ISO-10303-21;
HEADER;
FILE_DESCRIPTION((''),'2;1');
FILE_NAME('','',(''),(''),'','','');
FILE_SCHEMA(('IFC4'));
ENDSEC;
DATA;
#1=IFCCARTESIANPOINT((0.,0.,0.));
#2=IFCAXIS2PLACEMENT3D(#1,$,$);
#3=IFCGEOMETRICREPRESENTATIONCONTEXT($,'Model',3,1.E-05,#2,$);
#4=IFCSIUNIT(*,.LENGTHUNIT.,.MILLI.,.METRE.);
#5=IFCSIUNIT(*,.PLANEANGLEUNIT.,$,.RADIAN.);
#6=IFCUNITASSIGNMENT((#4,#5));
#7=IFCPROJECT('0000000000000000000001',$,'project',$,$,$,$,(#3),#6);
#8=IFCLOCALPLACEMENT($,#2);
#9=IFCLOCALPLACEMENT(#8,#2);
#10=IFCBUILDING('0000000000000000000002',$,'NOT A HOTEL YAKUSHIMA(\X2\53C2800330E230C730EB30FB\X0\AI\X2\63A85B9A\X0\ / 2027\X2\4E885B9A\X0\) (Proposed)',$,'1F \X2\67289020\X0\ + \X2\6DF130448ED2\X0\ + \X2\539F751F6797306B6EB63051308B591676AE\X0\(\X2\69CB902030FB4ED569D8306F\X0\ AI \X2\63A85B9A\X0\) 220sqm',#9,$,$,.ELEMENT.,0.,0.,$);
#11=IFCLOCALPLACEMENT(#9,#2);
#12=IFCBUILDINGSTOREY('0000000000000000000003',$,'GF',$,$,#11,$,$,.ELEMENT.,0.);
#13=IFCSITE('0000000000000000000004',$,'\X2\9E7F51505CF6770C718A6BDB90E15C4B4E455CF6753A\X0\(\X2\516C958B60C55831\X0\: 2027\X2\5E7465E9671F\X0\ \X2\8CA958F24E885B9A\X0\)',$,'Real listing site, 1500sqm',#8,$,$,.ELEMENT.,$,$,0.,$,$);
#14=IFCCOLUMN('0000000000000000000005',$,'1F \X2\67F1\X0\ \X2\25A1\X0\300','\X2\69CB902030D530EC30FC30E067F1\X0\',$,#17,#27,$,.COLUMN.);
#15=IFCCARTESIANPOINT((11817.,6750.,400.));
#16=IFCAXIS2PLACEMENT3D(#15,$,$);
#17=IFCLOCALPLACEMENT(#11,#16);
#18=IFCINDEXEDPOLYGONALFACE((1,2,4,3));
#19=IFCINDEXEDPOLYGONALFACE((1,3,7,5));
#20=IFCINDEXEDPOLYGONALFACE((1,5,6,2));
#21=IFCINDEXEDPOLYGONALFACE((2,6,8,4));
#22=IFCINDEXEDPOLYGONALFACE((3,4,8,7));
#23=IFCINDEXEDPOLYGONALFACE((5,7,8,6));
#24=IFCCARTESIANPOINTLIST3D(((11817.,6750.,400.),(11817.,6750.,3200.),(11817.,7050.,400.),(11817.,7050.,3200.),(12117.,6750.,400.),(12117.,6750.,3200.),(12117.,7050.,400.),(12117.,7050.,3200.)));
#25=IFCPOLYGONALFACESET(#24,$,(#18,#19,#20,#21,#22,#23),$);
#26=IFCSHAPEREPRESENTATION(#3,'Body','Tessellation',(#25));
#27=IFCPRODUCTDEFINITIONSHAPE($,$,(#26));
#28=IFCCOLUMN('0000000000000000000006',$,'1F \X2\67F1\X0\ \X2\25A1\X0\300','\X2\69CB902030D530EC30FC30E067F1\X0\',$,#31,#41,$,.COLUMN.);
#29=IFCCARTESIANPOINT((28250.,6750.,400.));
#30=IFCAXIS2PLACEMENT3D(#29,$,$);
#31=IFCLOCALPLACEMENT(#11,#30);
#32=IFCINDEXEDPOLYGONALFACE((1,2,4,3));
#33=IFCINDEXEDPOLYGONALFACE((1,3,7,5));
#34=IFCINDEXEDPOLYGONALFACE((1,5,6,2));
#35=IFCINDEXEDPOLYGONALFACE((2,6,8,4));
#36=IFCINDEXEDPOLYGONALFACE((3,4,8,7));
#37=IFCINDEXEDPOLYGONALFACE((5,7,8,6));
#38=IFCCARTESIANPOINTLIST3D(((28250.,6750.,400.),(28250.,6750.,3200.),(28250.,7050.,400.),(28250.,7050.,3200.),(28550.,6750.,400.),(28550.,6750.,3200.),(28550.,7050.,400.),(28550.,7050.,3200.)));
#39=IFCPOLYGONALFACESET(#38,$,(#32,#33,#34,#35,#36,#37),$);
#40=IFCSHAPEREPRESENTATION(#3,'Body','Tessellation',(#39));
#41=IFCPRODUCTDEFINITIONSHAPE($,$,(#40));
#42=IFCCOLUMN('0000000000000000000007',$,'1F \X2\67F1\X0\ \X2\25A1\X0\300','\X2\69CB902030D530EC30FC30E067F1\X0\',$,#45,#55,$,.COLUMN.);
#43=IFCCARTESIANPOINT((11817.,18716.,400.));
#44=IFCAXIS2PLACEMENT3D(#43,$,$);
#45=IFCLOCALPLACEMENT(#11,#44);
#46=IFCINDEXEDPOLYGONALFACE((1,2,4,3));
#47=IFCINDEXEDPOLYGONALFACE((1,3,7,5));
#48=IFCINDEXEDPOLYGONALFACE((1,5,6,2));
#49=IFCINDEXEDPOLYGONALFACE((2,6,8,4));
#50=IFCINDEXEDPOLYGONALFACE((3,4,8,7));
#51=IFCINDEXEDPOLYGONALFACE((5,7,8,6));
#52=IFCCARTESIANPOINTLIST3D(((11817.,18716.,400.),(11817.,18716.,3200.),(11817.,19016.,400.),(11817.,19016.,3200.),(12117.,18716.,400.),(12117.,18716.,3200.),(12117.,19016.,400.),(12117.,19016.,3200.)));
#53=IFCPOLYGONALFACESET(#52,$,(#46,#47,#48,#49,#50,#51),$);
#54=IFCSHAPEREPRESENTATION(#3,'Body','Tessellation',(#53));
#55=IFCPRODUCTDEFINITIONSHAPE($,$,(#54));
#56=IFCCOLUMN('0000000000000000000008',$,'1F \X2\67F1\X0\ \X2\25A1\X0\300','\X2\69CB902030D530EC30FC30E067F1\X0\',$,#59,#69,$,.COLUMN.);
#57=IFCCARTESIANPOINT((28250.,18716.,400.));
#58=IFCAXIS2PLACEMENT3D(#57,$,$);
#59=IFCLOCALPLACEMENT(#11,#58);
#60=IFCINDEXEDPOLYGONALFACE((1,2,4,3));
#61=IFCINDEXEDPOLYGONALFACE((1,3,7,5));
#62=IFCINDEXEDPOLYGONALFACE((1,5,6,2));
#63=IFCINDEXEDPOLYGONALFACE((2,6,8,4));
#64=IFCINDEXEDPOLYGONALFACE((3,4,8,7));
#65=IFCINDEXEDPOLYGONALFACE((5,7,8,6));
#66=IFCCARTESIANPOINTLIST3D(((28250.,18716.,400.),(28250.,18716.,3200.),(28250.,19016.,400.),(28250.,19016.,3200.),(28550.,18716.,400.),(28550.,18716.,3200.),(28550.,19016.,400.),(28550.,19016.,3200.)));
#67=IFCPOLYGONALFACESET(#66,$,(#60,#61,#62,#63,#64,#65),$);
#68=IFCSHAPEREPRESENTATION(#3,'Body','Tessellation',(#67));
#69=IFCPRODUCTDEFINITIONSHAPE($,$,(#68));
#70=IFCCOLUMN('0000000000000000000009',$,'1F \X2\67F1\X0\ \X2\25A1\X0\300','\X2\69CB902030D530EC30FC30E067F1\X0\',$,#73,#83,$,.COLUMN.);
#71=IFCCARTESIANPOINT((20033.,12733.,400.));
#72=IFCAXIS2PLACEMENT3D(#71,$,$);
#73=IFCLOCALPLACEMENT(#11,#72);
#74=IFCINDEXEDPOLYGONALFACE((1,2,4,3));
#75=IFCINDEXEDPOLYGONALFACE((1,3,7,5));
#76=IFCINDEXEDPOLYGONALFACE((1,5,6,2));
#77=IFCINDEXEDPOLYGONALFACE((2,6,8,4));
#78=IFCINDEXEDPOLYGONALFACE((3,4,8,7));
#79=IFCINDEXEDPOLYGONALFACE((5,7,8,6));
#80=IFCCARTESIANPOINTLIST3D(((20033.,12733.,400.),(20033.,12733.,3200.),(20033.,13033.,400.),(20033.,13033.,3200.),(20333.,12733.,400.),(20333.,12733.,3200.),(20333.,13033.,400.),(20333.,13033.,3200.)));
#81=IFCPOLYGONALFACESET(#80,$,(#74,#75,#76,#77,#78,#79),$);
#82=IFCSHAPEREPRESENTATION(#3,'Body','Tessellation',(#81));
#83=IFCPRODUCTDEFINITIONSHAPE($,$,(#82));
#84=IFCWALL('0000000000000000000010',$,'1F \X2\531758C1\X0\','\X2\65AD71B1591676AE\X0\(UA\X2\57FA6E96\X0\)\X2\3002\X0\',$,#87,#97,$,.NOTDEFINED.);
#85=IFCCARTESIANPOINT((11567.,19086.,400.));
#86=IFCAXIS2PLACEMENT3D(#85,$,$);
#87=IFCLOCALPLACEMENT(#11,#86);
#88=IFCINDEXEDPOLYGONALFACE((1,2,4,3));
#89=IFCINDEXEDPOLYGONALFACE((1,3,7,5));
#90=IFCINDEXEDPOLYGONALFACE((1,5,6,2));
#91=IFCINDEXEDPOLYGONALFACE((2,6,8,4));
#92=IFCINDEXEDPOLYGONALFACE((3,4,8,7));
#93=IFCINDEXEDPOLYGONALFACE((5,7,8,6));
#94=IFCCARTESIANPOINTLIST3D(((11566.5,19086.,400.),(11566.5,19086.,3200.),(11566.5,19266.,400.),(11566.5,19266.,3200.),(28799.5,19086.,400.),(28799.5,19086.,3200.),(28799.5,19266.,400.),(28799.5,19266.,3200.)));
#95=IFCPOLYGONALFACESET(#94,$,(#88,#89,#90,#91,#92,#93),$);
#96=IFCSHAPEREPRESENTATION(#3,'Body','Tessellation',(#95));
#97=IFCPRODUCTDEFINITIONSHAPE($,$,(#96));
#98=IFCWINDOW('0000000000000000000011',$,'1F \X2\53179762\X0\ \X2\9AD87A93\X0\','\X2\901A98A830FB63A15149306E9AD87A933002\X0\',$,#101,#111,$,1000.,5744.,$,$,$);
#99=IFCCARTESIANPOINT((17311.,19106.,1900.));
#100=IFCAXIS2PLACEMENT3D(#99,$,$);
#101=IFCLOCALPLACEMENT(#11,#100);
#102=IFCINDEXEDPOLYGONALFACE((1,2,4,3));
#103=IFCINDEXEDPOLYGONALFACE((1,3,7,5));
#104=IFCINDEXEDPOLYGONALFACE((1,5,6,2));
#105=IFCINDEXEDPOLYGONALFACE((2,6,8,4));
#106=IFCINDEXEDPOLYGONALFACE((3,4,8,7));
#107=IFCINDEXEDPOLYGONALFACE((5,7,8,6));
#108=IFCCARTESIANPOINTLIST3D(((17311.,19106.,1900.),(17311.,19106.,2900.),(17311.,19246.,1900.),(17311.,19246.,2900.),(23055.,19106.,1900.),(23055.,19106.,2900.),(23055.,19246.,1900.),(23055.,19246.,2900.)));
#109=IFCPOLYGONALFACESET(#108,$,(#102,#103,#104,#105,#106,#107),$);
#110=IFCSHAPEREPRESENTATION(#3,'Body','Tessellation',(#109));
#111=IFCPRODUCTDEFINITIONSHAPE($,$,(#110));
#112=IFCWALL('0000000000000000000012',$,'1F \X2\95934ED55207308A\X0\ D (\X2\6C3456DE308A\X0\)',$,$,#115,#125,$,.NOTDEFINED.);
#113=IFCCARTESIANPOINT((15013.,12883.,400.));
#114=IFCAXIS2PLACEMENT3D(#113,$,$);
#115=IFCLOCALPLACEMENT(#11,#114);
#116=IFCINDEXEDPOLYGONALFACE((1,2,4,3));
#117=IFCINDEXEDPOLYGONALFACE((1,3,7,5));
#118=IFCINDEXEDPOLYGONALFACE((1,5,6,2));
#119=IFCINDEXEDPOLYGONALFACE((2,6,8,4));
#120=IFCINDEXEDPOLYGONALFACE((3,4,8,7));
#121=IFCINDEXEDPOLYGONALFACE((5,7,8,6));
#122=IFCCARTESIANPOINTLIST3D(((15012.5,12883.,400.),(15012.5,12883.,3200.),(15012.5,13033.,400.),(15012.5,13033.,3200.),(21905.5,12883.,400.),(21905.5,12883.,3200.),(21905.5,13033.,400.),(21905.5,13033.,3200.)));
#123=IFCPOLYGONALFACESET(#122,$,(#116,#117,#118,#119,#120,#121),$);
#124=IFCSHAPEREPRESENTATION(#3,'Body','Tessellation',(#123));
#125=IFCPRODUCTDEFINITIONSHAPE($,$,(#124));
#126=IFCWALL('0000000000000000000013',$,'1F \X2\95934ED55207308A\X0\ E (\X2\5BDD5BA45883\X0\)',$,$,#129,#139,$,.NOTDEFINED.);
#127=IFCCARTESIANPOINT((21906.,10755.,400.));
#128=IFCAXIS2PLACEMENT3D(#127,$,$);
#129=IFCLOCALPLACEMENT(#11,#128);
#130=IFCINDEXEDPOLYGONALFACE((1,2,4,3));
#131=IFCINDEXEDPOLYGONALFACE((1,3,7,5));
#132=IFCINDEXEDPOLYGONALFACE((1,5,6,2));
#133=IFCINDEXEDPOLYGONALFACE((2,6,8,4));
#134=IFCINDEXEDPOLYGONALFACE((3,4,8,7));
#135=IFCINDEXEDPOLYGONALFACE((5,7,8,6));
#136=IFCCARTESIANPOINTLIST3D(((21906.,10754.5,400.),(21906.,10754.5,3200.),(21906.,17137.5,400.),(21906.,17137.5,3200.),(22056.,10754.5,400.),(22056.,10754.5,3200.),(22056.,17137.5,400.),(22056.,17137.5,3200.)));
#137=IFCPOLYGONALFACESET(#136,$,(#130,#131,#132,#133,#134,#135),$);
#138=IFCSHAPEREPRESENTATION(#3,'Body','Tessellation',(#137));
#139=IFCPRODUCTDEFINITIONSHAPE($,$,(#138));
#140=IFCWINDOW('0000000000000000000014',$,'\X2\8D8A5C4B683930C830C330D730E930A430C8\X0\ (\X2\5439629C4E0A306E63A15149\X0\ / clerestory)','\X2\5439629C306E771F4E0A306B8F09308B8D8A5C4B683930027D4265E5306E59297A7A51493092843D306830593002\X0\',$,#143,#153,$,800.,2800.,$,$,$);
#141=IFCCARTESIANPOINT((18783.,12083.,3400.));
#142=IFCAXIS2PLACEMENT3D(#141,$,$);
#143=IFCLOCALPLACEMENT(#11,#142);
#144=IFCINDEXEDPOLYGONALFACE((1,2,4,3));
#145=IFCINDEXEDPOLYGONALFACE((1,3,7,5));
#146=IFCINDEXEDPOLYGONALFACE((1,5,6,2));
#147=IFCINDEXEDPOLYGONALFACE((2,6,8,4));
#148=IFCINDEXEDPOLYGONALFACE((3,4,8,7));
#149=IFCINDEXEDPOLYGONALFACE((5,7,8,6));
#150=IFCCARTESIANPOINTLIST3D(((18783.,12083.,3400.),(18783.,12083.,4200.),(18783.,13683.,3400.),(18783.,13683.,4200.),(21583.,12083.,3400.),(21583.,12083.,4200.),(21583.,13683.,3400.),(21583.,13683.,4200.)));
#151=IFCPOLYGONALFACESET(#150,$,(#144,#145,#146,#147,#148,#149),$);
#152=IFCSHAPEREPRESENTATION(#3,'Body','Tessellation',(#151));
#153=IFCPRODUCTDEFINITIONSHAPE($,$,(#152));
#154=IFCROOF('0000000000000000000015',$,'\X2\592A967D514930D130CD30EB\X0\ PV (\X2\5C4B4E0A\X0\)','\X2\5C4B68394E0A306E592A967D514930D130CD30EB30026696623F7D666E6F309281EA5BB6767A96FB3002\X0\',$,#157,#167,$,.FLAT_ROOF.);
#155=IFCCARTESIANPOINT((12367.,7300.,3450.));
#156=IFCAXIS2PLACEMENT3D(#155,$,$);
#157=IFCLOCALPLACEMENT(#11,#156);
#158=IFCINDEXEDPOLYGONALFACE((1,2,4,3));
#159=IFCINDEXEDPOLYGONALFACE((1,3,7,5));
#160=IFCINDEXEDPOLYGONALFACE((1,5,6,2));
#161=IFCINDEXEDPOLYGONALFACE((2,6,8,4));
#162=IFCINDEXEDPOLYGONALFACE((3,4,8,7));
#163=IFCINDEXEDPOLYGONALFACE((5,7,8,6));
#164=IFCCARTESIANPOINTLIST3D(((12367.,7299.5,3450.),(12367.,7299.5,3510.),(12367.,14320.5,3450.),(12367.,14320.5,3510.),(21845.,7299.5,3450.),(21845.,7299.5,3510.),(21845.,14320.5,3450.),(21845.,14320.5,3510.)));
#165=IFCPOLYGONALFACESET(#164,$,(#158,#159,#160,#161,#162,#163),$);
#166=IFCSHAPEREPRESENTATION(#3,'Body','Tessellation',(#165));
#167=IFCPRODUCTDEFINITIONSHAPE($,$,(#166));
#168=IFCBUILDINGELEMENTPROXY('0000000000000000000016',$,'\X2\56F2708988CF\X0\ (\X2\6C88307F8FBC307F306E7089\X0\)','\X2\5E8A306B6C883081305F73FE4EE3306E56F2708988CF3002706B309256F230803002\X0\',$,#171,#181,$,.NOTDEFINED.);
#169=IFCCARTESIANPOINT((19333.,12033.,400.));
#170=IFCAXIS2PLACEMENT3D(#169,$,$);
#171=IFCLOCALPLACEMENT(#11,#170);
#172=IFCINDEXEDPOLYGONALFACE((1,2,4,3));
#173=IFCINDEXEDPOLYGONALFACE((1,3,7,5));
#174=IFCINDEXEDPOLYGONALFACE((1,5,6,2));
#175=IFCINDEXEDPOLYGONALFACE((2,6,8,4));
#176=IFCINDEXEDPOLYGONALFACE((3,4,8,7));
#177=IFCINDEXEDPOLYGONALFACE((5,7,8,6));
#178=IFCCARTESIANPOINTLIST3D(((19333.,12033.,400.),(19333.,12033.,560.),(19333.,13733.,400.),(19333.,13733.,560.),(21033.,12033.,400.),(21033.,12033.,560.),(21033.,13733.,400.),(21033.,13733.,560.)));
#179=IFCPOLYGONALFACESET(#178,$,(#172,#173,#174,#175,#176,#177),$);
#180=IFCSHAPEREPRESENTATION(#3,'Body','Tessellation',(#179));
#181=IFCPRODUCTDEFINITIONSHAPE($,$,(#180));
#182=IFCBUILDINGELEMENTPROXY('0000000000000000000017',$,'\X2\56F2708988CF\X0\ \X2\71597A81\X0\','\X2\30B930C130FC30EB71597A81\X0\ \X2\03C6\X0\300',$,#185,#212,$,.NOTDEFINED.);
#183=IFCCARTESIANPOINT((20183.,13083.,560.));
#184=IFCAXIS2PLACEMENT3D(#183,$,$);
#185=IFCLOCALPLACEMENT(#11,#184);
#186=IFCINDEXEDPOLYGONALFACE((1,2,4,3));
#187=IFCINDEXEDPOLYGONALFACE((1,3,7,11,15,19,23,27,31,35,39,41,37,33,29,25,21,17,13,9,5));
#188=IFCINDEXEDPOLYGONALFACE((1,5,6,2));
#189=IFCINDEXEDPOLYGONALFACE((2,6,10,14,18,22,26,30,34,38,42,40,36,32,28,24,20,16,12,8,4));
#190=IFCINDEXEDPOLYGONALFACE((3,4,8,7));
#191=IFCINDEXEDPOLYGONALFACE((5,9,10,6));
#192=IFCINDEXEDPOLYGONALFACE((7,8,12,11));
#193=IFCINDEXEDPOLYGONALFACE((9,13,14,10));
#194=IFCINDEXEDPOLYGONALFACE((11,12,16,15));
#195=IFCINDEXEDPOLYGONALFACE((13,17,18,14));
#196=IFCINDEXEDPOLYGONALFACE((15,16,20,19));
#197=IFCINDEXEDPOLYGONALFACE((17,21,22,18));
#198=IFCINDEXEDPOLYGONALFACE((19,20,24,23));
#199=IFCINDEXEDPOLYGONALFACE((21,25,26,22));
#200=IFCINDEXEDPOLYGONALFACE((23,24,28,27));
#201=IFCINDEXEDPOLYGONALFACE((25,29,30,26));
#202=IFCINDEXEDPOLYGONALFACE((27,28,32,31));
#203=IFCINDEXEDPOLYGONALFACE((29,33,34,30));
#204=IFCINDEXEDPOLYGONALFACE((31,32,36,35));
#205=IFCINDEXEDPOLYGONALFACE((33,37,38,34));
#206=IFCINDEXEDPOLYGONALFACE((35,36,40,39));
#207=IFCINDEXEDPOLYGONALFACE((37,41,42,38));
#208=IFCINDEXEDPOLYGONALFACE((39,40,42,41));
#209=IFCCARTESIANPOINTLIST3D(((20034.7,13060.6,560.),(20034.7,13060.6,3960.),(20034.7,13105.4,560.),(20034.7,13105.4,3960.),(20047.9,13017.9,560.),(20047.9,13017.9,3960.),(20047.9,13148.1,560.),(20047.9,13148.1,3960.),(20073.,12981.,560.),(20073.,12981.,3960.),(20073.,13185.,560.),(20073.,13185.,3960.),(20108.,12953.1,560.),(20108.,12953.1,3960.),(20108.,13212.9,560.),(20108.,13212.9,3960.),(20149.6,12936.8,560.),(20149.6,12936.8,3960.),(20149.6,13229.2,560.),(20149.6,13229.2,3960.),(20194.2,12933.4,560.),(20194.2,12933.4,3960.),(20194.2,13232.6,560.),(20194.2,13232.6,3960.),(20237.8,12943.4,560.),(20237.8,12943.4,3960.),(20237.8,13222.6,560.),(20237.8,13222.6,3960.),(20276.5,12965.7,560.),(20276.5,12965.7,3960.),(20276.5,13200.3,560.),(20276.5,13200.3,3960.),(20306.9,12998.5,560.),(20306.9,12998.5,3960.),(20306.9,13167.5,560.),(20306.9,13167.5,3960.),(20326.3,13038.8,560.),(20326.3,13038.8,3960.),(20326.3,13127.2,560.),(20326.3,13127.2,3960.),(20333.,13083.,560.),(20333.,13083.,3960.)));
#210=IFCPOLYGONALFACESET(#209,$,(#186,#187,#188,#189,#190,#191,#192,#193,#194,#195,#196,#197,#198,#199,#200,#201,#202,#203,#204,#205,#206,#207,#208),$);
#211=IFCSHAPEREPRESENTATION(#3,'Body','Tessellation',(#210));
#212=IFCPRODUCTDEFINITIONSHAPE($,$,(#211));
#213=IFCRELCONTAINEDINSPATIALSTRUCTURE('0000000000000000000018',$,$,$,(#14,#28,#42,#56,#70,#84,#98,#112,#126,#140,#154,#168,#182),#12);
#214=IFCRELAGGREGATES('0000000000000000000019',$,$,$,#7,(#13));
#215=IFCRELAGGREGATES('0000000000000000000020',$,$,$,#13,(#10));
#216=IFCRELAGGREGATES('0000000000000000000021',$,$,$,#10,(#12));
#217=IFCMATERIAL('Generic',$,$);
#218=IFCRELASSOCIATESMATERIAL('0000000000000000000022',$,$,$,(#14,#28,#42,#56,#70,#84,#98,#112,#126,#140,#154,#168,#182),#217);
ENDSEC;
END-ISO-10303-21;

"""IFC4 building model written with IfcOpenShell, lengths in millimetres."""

from ifc_helpers import new_model, si_unit, frame, frame_2d, origin, origin_2d, place, context, project, spatial, rectangle, circle, extrude, material, element, fill, save


model = new_model("IFC4")

# Units and contexts
model_context = context("Model", 3, precision=1e-05, world=origin())
ifc_project = project(units=[si_unit("LENGTHUNIT", "METRE", prefix="MILLI"), si_unit("PLANEANGLEUNIT", "RADIAN")], contexts=[model_context])

# Site, building, storey
site_placement = place(None, origin())
site = spatial("IfcSite", under=ifc_project, at=site_placement, Name="鹿児島県熊毛郡屋久島町(公開情報: 2027年早期 販売予定)", ObjectType="Real listing site, 1500sqm", CompositionType="ELEMENT", RefElevation=0.0)
building_placement = place(site_placement, origin())
building = spatial("IfcBuilding", under=site, at=building_placement, Name="NOT A HOTEL YAKUSHIMA(参考モデル・AI推定 / 2027予定) (Proposed)", ObjectType="1F 木造 + 深い軒 + 原生林に溶ける外皮(構造・仕様は AI 推定) 220sqm", CompositionType="ELEMENT", ElevationOfRefHeight=0.0, ElevationOfTerrain=0.0)
storey_placement = place(building_placement, origin())
storey = spatial("IfcBuildingStorey", under=building, at=storey_placement, Name="GF", CompositionType="ELEMENT", Elevation=0.0)

# Columns
ifc_material_1 = material(Name="Generic")
column_1_placement = place(storey_placement, frame((11817.0, 6750.0, 400.0)))
element("IfcColumn", 1, at=column_1_placement, inside=storey, material=ifc_material_1, Name="1F 柱 □300", Description="構造フレーム柱", PredefinedType="COLUMN", context=model_context, shape_type="SweptSolid", body=[
    extrude(rectangle(XDim=300.0, YDim=300.0, at=frame_2d((150.0, 150.0))), frame((11817.0, 6750.0, 400.0)), (0.0, 0.0, 1.0), 2800.0),
])
column_2_placement = place(storey_placement, frame((28250.0, 6750.0, 400.0)))
element("IfcColumn", 2, at=column_2_placement, inside=storey, material=ifc_material_1, Name="1F 柱 □300", Description="構造フレーム柱", PredefinedType="COLUMN", context=model_context, shape_type="SweptSolid", body=[
    extrude(rectangle(XDim=300.0, YDim=300.0, at=frame_2d((150.0, 150.0))), frame((28250.0, 6750.0, 400.0)), (0.0, 0.0, 1.0), 2800.0),
])
column_3_placement = place(storey_placement, frame((11817.0, 18716.0, 400.0)))
element("IfcColumn", 3, at=column_3_placement, inside=storey, material=ifc_material_1, Name="1F 柱 □300", Description="構造フレーム柱", PredefinedType="COLUMN", context=model_context, shape_type="SweptSolid", body=[
    extrude(rectangle(XDim=300.0, YDim=300.0, at=frame_2d((150.0, 150.0))), frame((11817.0, 18716.0, 400.0)), (0.0, 0.0, 1.0), 2800.0),
])
column_4_placement = place(storey_placement, frame((28250.0, 18716.0, 400.0)))
element("IfcColumn", 4, at=column_4_placement, inside=storey, material=ifc_material_1, Name="1F 柱 □300", Description="構造フレーム柱", PredefinedType="COLUMN", context=model_context, shape_type="SweptSolid", body=[
    extrude(rectangle(XDim=300.0, YDim=300.0, at=frame_2d((150.0, 150.0))), frame((28250.0, 18716.0, 400.0)), (0.0, 0.0, 1.0), 2800.0),
])
column_5_placement = place(storey_placement, frame((20033.0, 12733.0, 400.0)))
element("IfcColumn", 5, at=column_5_placement, inside=storey, material=ifc_material_1, Name="1F 柱 □300", Description="構造フレーム柱", PredefinedType="COLUMN", context=model_context, shape_type="SweptSolid", body=[
    extrude(rectangle(XDim=300.0, YDim=300.0, at=frame_2d((150.0, 150.0))), frame((20033.0, 12733.0, 400.0)), (0.0, 0.0, 1.0), 2800.0),
])

# Wall, opening, window
wall_1_placement = place(storey_placement, frame((11567.0, 19086.0, 400.0)))
wall_1 = element("IfcWall", 6, at=wall_1_placement, inside=storey, material=ifc_material_1, Name="1F 北壁", Description="断熱外皮(UA基準)。", PredefinedType="NOTDEFINED", context=model_context, shape_type="SweptSolid", body=[
    extrude(rectangle(XDim=17233.0, YDim=180.0, at=frame_2d((8616.0, 90.0))), frame((11567.0, 19086.0, 400.0)), (0.0, 0.0, 1.0), 2800.0),
])
opening_placement = place(storey_placement, frame((17311.0, 19106.0, 1900.0)))
opening = element("IfcOpeningElement", 7, at=opening_placement, cuts=wall_1, PredefinedType="NOTDEFINED", context=model_context, shape_type="SweptSolid", body=[
    extrude(rectangle(XDim=5744.0, YDim=140.0, at=frame_2d((2872.0, 70.0))), frame((17311.0, 19106.0, 1900.0)), (0.0, 0.0, 1.0), 1000.0),
])
window_1_placement = place(storey_placement, frame((17311.0, 19106.0, 1900.0)))
window_1 = element("IfcWindow", 8, at=window_1_placement, inside=storey, material=ifc_material_1, Name="1F 北面 高窓", Description="通風・採光の高窓。", OverallHeight=1000.0, OverallWidth=5744.0, context=model_context, shape_type="SweptSolid", body=[
    extrude(rectangle(XDim=5744.0, YDim=140.0, at=frame_2d((2872.0, 70.0))), frame((17311.0, 19106.0, 1900.0)), (0.0, 0.0, 1.0), 1000.0),
])
fill(opening, window_1)

# Walls
wall_2_placement = place(storey_placement, frame((15013.0, 12883.0, 400.0)))
element("IfcWall", 9, at=wall_2_placement, inside=storey, material=ifc_material_1, Name="1F 間仕切り D (水回り)", PredefinedType="NOTDEFINED", context=model_context, shape_type="SweptSolid", body=[
    extrude(rectangle(XDim=6893.0, YDim=150.0, at=frame_2d((3446.0, 75.0))), frame((15013.0, 12883.0, 400.0)), (0.0, 0.0, 1.0), 2800.0),
])
wall_3_placement = place(storey_placement, frame((21906.0, 10755.0, 400.0)))
element("IfcWall", 10, at=wall_3_placement, inside=storey, material=ifc_material_1, Name="1F 間仕切り E (寝室境)", PredefinedType="NOTDEFINED", context=model_context, shape_type="SweptSolid", body=[
    extrude(rectangle(XDim=150.0, YDim=6383.0, at=frame_2d((75.0, 3191.0))), frame((21906.0, 10755.0, 400.0)), (0.0, 0.0, 1.0), 2800.0),
])

# Window
window_2_placement = place(storey_placement, frame((18783.0, 12083.0, 3400.0)))
element("IfcWindow", 11, at=window_2_placement, inside=storey, material=ifc_material_1, Name="越屋根トップライト (吹抜上の採光 / clerestory)", Description="吹抜の真上に載る越屋根。終日の天空光を落とす。", OverallHeight=800.0, OverallWidth=2800.0, context=model_context, shape_type="SweptSolid", body=[
    extrude(rectangle(XDim=2800.0, YDim=1600.0, at=frame_2d((1400.0, 800.0))), frame((18783.0, 12083.0, 3400.0)), (0.0, 0.0, 1.0), 800.0),
])

# Roof
roof_placement = place(storey_placement, frame((12367.0, 7300.0, 3450.0)))
element("IfcRoof", 12, at=roof_placement, inside=storey, material=ifc_material_1, Name="太陽光パネル PV (屋上)", Description="屋根上の太陽光パネル。暖房給湯を自家発電。", PredefinedType="FLAT_ROOF", context=model_context, shape_type="SweptSolid", body=[
    extrude(rectangle(XDim=9478.0, YDim=7021.0, at=frame_2d((4739.0, 3510.0))), frame((12367.0, 7300.0, 3450.0)), (0.0, 0.0, 1.0), 60.0),
])

# Building element proxies
proxy_1_placement = place(storey_placement, frame((19333.0, 12033.0, 400.0)))
element("IfcBuildingElementProxy", 13, at=proxy_1_placement, inside=storey, material=ifc_material_1, Name="囲炉裏 (沈み込みの炉)", Description="床に沈めた現代の囲炉裏。火を囲む。", PredefinedType="NOTDEFINED", context=model_context, shape_type="SweptSolid", body=[
    extrude(rectangle(XDim=1700.0, YDim=1700.0, at=frame_2d((850.0, 850.0))), frame((19333.0, 12033.0, 400.0)), (0.0, 0.0, 1.0), 160.0),
])
proxy_2_placement = place(storey_placement, frame((20183.0, 13083.0, 560.0)))
element("IfcBuildingElementProxy", 14, at=proxy_2_placement, inside=storey, material=ifc_material_1, Name="囲炉裏 煙突", Description="スチール煙突 φ300", PredefinedType="NOTDEFINED", context=model_context, shape_type="SweptSolid", body=[
    extrude(circle(Radius=150.0, at=origin_2d()), frame((20183.0, 13083.0, 560.0)), (0.0, 0.0, 1.0), 3400.0),
])

save(model, "model.ifc")
